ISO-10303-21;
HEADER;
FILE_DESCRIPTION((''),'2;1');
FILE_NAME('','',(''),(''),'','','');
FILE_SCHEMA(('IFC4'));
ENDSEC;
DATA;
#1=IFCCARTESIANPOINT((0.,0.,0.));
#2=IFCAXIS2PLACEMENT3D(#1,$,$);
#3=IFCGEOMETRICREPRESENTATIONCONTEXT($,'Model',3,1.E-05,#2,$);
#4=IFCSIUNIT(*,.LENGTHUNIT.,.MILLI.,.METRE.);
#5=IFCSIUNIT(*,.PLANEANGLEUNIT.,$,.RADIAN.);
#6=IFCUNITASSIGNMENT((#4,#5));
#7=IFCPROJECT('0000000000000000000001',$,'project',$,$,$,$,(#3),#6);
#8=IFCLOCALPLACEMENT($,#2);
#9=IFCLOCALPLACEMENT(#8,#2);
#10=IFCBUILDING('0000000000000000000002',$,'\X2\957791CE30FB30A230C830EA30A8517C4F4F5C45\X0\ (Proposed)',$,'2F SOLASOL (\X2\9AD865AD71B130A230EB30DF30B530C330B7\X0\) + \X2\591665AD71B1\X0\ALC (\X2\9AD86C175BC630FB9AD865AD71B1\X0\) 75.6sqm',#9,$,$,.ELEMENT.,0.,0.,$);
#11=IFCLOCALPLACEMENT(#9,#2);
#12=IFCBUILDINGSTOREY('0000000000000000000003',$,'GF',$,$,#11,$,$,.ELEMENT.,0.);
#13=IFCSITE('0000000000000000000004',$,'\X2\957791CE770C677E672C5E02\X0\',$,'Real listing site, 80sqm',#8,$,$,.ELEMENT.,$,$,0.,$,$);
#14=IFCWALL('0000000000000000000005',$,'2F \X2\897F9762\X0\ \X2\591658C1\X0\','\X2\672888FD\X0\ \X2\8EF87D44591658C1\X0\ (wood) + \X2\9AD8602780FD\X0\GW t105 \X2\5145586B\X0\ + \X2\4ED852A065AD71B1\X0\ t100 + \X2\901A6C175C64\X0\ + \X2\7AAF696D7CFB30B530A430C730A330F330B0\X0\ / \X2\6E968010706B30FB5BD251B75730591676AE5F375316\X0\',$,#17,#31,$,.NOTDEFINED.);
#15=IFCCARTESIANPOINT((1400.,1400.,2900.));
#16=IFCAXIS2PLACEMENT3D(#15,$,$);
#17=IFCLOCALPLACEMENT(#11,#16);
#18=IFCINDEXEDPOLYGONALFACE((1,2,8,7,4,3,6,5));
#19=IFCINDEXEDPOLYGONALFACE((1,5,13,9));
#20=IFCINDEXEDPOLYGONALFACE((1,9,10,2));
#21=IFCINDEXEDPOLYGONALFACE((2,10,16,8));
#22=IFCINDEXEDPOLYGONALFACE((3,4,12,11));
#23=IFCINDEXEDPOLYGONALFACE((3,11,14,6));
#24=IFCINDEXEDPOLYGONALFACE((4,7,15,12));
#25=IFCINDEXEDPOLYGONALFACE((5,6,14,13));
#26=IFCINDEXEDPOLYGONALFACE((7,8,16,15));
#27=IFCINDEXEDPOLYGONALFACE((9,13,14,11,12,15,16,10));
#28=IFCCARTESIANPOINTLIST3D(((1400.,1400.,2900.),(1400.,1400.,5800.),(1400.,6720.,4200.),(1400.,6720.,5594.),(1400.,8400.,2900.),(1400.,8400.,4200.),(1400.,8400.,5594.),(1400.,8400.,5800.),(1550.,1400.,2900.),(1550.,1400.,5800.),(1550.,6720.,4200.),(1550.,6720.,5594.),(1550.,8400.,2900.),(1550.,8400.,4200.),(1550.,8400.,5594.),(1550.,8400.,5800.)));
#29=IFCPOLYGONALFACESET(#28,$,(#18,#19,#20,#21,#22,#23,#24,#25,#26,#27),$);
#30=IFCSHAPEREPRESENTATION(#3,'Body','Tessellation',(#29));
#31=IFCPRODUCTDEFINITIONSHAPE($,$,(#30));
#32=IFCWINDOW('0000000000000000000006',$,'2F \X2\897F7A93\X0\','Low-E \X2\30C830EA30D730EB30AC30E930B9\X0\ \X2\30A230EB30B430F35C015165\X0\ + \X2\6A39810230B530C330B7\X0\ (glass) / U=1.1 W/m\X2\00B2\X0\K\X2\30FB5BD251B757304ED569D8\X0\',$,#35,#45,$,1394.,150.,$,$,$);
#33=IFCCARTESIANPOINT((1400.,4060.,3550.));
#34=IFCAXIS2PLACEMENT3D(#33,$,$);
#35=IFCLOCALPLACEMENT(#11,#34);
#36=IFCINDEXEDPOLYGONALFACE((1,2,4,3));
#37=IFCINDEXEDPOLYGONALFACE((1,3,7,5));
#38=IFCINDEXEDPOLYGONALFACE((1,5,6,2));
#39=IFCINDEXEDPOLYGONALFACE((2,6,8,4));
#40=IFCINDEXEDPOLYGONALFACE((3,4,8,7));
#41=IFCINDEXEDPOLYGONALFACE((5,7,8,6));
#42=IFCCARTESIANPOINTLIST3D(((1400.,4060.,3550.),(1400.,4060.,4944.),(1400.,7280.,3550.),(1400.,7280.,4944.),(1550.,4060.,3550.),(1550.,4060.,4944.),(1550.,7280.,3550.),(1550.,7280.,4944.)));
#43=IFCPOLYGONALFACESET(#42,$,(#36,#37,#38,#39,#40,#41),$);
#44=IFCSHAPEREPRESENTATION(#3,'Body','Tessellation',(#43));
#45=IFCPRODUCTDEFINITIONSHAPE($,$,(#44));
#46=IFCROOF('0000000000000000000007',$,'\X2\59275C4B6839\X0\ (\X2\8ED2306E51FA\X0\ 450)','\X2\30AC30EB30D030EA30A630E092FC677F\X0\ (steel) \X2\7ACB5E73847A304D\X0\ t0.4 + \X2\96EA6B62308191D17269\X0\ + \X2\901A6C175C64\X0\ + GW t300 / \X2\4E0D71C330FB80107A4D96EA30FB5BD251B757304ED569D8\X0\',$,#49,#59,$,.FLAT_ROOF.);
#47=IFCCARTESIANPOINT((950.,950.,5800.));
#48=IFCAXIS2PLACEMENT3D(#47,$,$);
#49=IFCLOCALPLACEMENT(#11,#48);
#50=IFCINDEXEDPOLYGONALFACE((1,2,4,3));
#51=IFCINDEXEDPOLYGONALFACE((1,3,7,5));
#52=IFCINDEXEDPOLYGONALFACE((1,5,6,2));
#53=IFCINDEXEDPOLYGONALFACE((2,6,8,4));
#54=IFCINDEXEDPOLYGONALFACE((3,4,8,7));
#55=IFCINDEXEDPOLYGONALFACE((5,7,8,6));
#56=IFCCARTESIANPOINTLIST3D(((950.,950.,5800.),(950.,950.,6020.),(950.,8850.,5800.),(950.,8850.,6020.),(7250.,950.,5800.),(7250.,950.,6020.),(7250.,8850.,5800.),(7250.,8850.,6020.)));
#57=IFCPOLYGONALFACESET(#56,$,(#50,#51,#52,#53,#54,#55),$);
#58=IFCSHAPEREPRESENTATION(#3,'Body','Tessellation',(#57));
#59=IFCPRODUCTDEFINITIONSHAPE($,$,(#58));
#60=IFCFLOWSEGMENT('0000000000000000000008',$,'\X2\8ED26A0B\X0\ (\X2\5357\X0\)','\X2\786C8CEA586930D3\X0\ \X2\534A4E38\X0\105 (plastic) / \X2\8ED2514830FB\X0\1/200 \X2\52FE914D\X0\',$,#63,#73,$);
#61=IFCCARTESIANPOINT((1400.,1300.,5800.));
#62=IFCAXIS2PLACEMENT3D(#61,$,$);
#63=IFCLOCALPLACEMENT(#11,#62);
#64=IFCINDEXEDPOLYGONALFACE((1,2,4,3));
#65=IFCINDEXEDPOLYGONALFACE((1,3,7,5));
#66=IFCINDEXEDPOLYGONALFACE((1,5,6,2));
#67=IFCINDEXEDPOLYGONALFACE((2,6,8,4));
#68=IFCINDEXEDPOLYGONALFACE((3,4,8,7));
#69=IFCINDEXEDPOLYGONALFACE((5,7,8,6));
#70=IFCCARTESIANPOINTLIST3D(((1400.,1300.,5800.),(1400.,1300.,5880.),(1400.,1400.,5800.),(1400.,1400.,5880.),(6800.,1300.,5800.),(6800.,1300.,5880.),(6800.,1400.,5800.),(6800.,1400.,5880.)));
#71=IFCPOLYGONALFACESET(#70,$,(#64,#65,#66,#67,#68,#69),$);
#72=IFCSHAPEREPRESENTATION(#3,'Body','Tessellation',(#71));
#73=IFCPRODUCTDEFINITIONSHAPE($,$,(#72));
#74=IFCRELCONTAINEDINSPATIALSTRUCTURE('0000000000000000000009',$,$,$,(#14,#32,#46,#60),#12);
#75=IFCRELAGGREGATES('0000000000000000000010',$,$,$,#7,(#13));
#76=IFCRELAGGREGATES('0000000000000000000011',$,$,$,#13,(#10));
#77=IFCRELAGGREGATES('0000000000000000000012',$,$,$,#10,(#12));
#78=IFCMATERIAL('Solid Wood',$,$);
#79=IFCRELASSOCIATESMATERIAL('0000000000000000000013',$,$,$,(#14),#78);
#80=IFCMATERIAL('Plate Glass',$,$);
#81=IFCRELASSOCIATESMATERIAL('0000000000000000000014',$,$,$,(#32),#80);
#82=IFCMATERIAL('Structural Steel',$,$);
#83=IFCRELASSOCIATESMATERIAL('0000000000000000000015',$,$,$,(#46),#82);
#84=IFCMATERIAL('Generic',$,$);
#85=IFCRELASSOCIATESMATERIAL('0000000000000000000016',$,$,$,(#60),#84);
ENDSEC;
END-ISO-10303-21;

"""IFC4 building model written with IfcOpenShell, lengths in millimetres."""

from ifc_helpers import new_model, si_unit, frame, frame_2d, origin, place, context, project, spatial, rectangle, extrude, material, element, fill, save


model = new_model("IFC4")

# Units and contexts
model_context = context("Model", 3, precision=1e-05, world=origin())
ifc_project = project(units=[si_unit("LENGTHUNIT", "METRE", prefix="MILLI"), si_unit("PLANEANGLEUNIT", "RADIAN")], contexts=[model_context])

# Site, building, storey
site_placement = place(None, origin())
site = spatial("IfcSite", under=ifc_project, at=site_placement, Name="長野県松本市", ObjectType="Real listing site, 80sqm", CompositionType="ELEMENT", RefElevation=0.0)
building_placement = place(site_placement, origin())
building = spatial("IfcBuilding", under=site, at=building_placement, Name="長野・アトリエ兼住居 (Proposed)", ObjectType="2F SOLASOL (高断熱アルミサッシ) + 外断熱ALC (高気密・高断熱) 75.6sqm", CompositionType="ELEMENT", ElevationOfRefHeight=0.0, ElevationOfTerrain=0.0)
storey_placement = place(building_placement, origin())
storey = spatial("IfcBuildingStorey", under=building, at=storey_placement, Name="GF", CompositionType="ELEMENT", Elevation=0.0)

# Shared definitions
ifc_material_1 = material(Name="Solid Wood")

# Shared definitions
ifc_material_2 = material(Name="Plate Glass")

# Wall, opening, window
wall_1_placement = place(storey_placement, frame((1400.0, 1400.0, 2900.0)))
wall_1 = element("IfcWall", 1, at=wall_1_placement, inside=storey, material=ifc_material_1, Name="2F 西面 外壁", Description="木製 軸組外壁 (wood) + 高性能GW t105 充填 + 付加断熱 t100 + 通気層 + 窯業系サイディング / 準耐火・寒冷地外皮強化", PredefinedType="NOTDEFINED", context=model_context, shape_type="SweptSolid", body=[
    extrude(rectangle(XDim=150.0, YDim=7000.0, at=frame_2d((75.0, 3500.0))), frame((1400.0, 1400.0, 2900.0)), (0.0, 0.0, 1.0), 2900.0),
])
opening_1_placement = place(storey_placement, frame((1400.0, 4060.0, 3550.0)))
opening_1 = element("IfcOpeningElement", 2, at=opening_1_placement, cuts=wall_1, PredefinedType="NOTDEFINED", context=model_context, shape_type="SweptSolid", body=[
    extrude(rectangle(XDim=150.0, YDim=3220.0, at=frame_2d((75.0, 1610.0))), frame((1400.0, 4060.0, 3550.0)), (0.0, 0.0, 1.0), 1394.0),
])
window_1_placement = place(storey_placement, frame((1400.0, 4060.0, 3550.0)))
window_1 = element("IfcWindow", 3, at=window_1_placement, inside=storey, material=ifc_material_2, Name="2F 西窓", Description="Low-E トリプルガラス アルゴン封入 + 樹脂サッシ (glass) / U=1.1 W/m²K・寒冷地仕様", OverallHeight=1394.0, OverallWidth=150.0, context=model_context, shape_type="SweptSolid", body=[
    extrude(rectangle(XDim=150.0, YDim=3220.0, at=frame_2d((75.0, 1610.0))), frame((1400.0, 4060.0, 3550.0)), (0.0, 0.0, 1.0), 1394.0),
])
fill(opening_1, window_1)

# Roof
ifc_material_3 = material(Name="Structural Steel")
roof_placement = place(storey_placement, frame((950.0, 950.0, 5800.0)))
element("IfcRoof", 4, at=roof_placement, inside=storey, material=ifc_material_3, Name="大屋根 (軒の出 450)", Description="ガルバリウム鋼板 (steel) 立平葺き t0.4 + 雪止め金物 + 通気層 + GW t300 / 不燃・耐積雪・寒冷地仕様", PredefinedType="FLAT_ROOF", context=model_context, shape_type="SweptSolid", body=[
    extrude(rectangle(XDim=6300.0, YDim=7900.0, at=frame_2d((3150.0, 3950.0))), frame((950.0, 950.0, 5800.0)), (0.0, 0.0, 1.0), 220.0),
])

# Flow segment
ifc_material_4 = material(Name="Generic")
flow_segment_placement = place(storey_placement, frame((1400.0, 1300.0, 5800.0)))
element("IfcFlowSegment", 5, at=flow_segment_placement, inside=storey, material=ifc_material_4, Name="軒樋 (南)", Description="硬質塩ビ 半丸105 (plastic) / 軒先・1/200 勾配", context=model_context, shape_type="SweptSolid", body=[
    extrude(rectangle(XDim=5400.0, YDim=100.0, at=frame_2d((2700.0, 50.0))), frame((1400.0, 1300.0, 5800.0)), (0.0, 0.0, 1.0), 80.0),
])

save(model, "model.ifc")
